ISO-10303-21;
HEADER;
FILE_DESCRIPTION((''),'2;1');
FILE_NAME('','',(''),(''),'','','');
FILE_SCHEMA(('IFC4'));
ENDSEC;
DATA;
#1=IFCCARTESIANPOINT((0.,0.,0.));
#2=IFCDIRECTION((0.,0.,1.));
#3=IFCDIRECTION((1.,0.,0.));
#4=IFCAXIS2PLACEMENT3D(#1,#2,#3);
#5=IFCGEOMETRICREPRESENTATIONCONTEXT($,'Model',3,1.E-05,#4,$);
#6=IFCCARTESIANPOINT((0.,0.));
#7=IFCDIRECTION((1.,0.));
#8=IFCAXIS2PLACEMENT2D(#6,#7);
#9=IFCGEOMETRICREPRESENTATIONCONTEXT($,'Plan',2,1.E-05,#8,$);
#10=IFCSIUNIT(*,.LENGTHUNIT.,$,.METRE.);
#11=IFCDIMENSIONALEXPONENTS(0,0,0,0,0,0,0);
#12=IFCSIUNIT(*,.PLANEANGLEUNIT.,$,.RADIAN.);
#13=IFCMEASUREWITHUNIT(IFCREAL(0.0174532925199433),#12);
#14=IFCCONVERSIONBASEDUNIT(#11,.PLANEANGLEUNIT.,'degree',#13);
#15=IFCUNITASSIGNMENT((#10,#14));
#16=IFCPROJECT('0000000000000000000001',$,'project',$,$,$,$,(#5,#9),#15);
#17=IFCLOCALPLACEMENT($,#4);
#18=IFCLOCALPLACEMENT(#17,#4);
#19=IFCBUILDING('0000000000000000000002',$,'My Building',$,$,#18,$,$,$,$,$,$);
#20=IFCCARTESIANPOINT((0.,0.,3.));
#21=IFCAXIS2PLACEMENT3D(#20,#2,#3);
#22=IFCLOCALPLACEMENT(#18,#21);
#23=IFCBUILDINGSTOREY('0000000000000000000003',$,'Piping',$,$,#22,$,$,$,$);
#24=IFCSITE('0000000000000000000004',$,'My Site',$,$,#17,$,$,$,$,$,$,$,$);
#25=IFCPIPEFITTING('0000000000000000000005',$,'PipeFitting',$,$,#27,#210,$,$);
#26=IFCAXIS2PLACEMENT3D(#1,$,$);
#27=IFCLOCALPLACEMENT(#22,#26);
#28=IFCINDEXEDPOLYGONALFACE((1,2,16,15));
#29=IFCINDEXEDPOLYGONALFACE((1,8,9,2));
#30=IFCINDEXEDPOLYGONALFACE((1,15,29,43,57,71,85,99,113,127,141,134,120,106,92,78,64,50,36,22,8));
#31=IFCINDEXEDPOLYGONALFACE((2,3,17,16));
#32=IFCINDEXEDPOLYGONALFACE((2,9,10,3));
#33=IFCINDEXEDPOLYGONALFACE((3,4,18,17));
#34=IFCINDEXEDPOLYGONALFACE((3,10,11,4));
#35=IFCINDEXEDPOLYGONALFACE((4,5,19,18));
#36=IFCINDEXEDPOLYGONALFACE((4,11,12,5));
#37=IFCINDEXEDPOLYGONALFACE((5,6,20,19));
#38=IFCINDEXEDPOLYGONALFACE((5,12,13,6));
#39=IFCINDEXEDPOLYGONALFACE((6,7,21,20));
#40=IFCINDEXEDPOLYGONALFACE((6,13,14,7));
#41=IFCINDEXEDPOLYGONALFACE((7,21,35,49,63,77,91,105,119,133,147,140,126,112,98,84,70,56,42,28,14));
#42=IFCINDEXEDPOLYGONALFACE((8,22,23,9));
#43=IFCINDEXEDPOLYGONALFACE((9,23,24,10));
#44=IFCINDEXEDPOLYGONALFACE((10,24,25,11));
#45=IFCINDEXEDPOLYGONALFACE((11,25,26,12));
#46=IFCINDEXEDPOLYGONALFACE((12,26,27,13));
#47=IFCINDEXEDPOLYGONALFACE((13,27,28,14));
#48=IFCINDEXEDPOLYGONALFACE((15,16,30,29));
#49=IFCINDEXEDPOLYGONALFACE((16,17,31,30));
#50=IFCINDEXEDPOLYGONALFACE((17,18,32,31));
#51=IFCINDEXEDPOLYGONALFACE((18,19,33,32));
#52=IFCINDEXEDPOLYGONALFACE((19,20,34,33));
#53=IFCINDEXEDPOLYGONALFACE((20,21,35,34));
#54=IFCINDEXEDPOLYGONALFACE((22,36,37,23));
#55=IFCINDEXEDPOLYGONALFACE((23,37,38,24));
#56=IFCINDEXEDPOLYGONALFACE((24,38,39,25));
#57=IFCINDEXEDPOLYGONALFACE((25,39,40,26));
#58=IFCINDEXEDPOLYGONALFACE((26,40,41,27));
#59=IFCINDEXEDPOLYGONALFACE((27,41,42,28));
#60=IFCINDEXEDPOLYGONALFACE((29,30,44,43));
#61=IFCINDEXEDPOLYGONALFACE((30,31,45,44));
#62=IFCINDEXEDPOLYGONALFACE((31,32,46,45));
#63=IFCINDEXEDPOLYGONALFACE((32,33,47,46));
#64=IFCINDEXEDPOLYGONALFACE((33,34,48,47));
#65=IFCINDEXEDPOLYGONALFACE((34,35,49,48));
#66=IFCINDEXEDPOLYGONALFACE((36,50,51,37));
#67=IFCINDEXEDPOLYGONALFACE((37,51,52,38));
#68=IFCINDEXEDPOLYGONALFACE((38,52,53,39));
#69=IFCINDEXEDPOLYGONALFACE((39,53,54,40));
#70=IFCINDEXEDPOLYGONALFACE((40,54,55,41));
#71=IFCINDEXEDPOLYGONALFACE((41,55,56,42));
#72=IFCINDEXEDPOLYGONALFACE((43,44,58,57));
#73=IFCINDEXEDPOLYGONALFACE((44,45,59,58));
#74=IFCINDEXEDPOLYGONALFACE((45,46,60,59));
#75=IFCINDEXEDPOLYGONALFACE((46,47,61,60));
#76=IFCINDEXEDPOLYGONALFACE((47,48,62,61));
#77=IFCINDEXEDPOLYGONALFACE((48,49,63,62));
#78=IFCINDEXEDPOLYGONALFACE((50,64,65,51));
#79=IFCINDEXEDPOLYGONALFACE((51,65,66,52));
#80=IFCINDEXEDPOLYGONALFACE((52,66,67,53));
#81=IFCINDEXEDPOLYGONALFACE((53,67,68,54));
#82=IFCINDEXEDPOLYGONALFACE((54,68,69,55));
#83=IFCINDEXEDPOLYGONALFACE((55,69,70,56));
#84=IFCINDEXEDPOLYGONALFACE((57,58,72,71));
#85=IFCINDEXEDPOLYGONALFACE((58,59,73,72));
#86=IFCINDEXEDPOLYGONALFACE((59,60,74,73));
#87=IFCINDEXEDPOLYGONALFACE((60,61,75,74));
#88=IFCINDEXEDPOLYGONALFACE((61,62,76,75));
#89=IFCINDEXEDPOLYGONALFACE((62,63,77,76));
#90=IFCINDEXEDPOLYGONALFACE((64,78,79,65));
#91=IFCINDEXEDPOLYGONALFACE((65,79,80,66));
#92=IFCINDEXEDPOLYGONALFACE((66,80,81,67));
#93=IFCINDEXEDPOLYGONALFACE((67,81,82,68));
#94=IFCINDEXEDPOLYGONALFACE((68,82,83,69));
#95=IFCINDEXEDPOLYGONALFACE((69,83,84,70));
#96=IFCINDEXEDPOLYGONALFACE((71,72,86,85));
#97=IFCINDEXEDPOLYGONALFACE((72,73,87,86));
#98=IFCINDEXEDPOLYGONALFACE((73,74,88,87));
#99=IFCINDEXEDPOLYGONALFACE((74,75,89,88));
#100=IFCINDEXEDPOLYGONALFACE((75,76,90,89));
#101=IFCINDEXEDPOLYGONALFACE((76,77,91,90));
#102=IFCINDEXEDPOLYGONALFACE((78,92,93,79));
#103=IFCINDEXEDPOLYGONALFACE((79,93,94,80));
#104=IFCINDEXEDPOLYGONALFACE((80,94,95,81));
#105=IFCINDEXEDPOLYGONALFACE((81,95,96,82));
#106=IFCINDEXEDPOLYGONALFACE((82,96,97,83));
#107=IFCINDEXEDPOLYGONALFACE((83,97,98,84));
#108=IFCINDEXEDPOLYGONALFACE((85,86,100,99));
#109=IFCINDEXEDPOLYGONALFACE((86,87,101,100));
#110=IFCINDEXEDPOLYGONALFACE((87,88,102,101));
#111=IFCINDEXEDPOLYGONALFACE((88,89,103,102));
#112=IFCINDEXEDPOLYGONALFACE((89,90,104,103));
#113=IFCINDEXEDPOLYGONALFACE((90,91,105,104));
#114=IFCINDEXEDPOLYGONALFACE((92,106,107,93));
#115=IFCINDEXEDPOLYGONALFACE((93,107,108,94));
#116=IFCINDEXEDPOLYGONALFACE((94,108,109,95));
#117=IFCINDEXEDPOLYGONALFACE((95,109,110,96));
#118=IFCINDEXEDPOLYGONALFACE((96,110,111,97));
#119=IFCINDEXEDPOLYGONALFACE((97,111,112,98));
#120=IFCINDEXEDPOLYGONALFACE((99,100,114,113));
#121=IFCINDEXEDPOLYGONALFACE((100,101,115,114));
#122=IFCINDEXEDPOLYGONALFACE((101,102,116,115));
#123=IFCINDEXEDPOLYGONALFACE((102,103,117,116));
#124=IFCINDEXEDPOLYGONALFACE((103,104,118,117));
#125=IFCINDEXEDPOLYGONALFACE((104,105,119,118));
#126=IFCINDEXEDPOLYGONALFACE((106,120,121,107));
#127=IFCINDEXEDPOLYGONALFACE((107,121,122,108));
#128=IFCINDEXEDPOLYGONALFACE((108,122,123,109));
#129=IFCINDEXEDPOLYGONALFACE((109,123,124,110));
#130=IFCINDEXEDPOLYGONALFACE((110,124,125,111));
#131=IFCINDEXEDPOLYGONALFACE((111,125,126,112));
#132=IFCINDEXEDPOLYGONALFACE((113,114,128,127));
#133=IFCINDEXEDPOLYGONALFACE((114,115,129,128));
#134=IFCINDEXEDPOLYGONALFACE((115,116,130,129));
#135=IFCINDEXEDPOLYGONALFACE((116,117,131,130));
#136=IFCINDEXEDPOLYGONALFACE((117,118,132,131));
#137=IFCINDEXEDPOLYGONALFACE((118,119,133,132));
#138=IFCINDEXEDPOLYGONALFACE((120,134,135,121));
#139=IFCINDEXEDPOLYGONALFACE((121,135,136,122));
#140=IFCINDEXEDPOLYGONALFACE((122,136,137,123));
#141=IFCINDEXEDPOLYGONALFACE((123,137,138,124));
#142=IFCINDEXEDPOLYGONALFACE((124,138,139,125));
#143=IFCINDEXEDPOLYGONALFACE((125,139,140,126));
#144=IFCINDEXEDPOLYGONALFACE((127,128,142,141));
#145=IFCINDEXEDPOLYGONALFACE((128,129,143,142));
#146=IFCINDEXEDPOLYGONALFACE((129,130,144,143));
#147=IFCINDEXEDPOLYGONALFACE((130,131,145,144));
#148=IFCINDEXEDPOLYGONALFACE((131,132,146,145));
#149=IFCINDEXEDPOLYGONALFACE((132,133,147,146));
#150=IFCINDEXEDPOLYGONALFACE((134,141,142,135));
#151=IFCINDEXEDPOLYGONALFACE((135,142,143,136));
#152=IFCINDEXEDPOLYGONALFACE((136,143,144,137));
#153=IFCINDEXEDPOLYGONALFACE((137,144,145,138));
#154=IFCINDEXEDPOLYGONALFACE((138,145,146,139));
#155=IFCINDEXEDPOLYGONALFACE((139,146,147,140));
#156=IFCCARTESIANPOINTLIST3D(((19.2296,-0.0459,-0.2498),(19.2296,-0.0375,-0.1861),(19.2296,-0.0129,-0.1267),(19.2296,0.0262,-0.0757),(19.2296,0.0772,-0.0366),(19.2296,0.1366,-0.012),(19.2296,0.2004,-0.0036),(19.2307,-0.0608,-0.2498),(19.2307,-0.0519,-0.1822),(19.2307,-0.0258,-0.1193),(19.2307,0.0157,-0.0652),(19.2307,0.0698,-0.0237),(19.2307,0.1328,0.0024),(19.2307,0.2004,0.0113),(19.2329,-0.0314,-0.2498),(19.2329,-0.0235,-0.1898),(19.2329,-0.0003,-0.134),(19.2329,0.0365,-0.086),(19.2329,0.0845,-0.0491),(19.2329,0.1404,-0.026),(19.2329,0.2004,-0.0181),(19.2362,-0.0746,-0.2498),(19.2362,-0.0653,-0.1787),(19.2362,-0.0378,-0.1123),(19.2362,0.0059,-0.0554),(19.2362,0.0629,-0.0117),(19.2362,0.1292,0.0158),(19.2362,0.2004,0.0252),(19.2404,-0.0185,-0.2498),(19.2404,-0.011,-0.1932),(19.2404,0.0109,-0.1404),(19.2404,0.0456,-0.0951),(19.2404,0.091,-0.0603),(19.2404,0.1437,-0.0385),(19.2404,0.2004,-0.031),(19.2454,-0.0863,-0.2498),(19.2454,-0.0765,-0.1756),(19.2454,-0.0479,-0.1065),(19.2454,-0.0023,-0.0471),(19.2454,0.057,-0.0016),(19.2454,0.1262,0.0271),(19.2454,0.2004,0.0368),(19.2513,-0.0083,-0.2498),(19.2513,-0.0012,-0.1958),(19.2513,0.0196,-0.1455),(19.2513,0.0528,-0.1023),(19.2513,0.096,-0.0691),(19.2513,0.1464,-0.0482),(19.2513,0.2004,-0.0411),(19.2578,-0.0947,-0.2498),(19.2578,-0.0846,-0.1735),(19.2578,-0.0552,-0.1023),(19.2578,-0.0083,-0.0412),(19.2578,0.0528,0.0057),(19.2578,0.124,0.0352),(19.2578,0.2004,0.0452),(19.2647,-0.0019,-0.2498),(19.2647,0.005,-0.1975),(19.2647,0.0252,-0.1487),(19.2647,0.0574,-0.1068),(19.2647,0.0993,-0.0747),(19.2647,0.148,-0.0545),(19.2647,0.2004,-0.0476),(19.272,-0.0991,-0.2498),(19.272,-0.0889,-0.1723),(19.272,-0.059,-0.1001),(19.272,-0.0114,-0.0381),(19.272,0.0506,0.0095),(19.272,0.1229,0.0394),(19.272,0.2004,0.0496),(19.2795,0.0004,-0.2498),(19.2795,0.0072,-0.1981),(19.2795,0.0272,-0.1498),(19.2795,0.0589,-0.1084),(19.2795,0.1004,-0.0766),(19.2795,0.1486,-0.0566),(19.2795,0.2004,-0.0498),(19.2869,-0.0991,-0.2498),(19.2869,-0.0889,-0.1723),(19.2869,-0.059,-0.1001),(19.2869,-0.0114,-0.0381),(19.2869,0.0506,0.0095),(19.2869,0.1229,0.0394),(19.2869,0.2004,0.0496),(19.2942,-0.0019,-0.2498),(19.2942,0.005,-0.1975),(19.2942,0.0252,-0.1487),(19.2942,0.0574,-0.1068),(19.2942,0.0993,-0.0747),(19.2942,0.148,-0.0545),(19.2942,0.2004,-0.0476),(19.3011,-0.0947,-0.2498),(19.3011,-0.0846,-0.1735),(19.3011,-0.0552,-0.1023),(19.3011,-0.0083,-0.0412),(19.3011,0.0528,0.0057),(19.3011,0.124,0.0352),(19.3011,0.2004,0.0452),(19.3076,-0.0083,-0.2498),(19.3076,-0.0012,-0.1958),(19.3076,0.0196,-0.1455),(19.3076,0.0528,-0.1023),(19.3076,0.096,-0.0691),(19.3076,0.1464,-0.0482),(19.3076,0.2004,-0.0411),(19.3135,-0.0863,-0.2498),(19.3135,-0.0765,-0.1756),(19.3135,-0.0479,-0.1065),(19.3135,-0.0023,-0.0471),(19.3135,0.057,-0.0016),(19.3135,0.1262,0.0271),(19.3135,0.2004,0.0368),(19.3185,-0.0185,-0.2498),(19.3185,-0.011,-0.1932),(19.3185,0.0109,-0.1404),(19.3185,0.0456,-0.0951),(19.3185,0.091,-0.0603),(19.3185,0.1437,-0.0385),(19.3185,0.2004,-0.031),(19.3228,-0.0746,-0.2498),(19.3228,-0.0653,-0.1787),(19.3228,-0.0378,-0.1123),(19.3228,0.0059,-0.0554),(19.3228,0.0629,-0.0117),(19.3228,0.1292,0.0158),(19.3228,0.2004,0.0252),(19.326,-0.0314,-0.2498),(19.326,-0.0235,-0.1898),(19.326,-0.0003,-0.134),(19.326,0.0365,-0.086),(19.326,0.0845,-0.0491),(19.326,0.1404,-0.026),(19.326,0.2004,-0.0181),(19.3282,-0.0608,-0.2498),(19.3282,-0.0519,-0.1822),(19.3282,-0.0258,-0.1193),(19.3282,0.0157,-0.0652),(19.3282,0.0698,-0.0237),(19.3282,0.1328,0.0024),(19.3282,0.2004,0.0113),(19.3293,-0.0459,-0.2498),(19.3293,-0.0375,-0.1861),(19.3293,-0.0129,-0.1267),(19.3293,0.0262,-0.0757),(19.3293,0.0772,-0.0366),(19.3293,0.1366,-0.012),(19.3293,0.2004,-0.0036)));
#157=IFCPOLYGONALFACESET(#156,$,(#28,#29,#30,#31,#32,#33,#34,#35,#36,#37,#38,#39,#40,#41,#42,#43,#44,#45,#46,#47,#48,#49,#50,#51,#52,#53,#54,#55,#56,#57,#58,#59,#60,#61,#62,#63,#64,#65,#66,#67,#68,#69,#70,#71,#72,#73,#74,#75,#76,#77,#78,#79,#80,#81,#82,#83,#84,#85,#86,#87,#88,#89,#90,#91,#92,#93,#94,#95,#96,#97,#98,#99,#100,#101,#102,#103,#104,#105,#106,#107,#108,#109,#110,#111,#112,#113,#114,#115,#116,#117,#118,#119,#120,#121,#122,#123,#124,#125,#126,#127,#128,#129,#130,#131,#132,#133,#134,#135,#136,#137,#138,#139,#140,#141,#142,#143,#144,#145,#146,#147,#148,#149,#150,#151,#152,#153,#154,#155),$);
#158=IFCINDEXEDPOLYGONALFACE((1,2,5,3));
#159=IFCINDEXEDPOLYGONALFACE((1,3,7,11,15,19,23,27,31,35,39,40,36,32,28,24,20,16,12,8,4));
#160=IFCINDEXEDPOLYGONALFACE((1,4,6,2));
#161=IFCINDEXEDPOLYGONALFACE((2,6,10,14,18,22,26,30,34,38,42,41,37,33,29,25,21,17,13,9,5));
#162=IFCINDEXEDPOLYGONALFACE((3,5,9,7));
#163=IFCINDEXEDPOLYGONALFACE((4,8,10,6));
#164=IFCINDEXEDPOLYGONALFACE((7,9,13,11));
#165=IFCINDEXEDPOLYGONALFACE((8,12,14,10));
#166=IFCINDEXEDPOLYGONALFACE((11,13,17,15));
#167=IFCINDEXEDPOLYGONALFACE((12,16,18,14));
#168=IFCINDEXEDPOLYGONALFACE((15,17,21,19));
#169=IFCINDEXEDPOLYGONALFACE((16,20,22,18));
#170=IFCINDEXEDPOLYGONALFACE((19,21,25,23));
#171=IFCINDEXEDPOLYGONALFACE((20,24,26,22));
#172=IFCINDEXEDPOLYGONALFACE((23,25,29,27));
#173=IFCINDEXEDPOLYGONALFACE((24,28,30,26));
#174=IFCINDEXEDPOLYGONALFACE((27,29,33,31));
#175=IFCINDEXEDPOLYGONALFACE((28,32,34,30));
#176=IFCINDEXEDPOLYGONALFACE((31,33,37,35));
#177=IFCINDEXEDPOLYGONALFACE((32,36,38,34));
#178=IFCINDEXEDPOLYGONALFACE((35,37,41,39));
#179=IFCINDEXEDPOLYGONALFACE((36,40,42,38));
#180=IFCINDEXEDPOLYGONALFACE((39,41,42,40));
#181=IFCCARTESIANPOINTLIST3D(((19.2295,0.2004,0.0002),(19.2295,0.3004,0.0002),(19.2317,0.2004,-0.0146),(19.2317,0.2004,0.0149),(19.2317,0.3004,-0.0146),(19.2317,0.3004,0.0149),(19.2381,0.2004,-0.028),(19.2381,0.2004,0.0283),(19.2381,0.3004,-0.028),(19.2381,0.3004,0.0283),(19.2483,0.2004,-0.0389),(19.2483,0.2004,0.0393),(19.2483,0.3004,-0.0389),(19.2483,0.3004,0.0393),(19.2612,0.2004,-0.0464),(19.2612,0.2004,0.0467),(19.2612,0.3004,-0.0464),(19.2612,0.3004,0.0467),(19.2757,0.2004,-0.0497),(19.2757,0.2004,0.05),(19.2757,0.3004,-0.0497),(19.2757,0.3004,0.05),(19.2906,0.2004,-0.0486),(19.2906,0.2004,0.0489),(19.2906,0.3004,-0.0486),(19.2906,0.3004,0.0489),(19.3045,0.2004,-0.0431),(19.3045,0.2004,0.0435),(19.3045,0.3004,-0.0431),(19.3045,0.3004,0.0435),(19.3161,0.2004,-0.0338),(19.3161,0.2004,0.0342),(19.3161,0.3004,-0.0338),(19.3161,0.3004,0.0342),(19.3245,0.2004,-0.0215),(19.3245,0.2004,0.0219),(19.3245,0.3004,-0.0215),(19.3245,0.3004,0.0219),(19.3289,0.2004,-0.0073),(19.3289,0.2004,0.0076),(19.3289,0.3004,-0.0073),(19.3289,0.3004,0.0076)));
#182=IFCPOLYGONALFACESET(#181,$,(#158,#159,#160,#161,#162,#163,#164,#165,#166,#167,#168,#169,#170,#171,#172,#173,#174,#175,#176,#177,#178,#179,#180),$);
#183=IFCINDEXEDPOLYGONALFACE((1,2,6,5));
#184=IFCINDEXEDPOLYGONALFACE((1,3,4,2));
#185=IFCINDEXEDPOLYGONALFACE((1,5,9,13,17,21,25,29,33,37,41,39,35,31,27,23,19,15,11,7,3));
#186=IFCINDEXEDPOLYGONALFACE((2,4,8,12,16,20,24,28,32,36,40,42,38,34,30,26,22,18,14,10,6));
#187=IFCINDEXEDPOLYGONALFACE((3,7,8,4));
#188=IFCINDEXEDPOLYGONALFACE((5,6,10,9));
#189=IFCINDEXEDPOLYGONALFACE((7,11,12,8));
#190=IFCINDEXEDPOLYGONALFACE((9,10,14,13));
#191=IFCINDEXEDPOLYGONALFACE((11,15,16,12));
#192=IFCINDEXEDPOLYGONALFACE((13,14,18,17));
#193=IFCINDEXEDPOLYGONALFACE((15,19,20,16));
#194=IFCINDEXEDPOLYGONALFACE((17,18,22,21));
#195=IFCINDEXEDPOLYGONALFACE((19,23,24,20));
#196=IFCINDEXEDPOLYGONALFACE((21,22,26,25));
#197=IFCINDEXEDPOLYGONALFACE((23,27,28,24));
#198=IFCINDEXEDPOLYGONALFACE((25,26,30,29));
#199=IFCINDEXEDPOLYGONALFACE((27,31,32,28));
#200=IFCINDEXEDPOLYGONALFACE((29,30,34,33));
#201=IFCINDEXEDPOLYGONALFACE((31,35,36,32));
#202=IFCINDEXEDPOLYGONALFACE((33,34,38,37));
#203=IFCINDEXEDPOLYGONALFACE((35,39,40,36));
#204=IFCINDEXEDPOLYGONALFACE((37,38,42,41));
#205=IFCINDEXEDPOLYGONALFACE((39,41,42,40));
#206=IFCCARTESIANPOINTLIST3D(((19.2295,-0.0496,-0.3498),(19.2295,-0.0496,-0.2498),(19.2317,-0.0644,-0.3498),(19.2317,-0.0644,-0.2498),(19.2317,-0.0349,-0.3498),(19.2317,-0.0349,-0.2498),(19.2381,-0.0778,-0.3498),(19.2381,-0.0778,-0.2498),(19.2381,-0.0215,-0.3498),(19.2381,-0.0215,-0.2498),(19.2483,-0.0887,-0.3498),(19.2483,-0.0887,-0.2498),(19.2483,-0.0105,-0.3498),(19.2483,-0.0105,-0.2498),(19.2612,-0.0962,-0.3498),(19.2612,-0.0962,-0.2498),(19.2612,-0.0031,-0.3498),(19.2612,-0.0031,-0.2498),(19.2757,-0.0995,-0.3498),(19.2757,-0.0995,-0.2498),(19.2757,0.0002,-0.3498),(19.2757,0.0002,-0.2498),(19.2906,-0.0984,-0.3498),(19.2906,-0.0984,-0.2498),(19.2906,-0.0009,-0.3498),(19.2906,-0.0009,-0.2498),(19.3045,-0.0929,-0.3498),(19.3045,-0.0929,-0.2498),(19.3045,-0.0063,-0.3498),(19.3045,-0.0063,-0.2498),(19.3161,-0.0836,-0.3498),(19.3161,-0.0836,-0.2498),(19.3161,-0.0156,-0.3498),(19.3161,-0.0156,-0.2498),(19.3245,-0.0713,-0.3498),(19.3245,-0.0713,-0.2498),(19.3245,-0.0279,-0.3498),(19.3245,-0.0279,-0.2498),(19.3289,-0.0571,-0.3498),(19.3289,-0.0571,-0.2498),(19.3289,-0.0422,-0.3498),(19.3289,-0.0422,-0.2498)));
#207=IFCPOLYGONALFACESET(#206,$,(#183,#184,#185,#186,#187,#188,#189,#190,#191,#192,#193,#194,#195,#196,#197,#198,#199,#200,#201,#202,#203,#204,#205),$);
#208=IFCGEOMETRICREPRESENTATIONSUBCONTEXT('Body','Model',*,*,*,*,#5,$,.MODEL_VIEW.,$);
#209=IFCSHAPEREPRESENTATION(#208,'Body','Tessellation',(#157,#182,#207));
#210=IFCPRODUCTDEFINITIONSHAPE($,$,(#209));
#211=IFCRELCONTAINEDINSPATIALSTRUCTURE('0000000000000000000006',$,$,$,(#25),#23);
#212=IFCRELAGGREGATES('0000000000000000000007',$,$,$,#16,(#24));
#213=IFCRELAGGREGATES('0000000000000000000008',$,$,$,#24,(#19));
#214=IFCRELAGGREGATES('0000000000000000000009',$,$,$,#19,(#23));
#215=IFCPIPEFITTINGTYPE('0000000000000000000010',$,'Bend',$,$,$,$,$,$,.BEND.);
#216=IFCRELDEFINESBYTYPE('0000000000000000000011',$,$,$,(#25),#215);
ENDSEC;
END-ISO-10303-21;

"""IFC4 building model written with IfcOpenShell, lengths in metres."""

from ifc_helpers import new_model, entity, si_unit, converted_unit, frame, origin_with_axes, origin_2d_with_axis, place, context, subcontext, project, spatial, circle, extrude, source, transform, mapped, type_object, type_shapes, element, save


model = new_model("IFC4")

# Units and contexts
model_context = context("Model", 3, precision=1e-05, world=origin_with_axes())
plan_context = context("Plan", 2, precision=1e-05, world=origin_2d_with_axis())
body_context = subcontext(model_context, "Body", "Model", "MODEL_VIEW")
ifc_project = project(units=[si_unit("LENGTHUNIT", "METRE"), converted_unit("PLANEANGLEUNIT", "degree", entity("IfcReal", 0.0174532925199433), si_unit("PLANEANGLEUNIT", "RADIAN"), dimensions=[0, 0, 0, 0, 0, 0, 0])], contexts=[model_context, plan_context])

# Site, building, storey
site_placement = place(None, origin_with_axes())
site = spatial("IfcSite", under=ifc_project, at=site_placement, Name="My Site")
building_placement = place(site_placement, origin_with_axes())
building = spatial("IfcBuilding", under=site, at=building_placement, Name="My Building")
storey_placement = place(building_placement, frame((0.0, 0.0, 3.0), z_axis=(0.0, 0.0, 1.0), x_axis=(1.0, 0.0, 0.0)))
storey = spatial("IfcBuildingStorey", under=building, at=storey_placement, Name="Piping")

# Pipe fitting
pipe_fitting_type = type_object("IfcPipeFittingType", Name="Bend", PredefinedType="BEND")
shared_shape = source(origin_with_axes(), body_context, "Body", "SolidModel", [
    entity("IfcSweptDiskSolid", entity("IfcIndexedPolyCurve", entity("IfcCartesianPointList3D", [[0.0, 0.0, -0.1], [0.0, -0.0732, -0.2768], [0.0, -0.25, -0.35]]), [entity("IfcArcIndex", [1, 2, 3])]), 0.05),
    extrude(circle(Radius=0.05), origin_with_axes(), (0.0, 0.0, -1.0), 0.1),
    extrude(circle(Radius=0.05), frame((0.0, -0.25, -0.35), z_axis=(0.0, -1.0, 0.0), x_axis=(1.0, 0.0, 0.0)), (0.0, 0.0, 1.0), 0.1),
])
type_shapes(pipe_fitting_type, [shared_shape])
for number, where, z_axis, x_axis, name in (
    (1, (19.2795, 0.3004, 0.0002), (0.0, 1.0, 0.0), (-1.0, 0.0, 0.0), "PipeFitting"),
):
    element("IfcPipeFitting", number, at=place(storey_placement, frame(where, z_axis=z_axis, x_axis=x_axis)), inside=storey, type_object=pipe_fitting_type, Name=name, context=body_context, shape_type="MappedRepresentation", body=[
        mapped(shared_shape, transform((0.0, 0.0, 0.0), x_axis=(1.0, 0.0, 0.0), y_axis=(0.0, 1.0, 0.0), z_axis=(0.0, 0.0, 1.0), scale=1.0)),
    ])

save(model, "model.ifc")
